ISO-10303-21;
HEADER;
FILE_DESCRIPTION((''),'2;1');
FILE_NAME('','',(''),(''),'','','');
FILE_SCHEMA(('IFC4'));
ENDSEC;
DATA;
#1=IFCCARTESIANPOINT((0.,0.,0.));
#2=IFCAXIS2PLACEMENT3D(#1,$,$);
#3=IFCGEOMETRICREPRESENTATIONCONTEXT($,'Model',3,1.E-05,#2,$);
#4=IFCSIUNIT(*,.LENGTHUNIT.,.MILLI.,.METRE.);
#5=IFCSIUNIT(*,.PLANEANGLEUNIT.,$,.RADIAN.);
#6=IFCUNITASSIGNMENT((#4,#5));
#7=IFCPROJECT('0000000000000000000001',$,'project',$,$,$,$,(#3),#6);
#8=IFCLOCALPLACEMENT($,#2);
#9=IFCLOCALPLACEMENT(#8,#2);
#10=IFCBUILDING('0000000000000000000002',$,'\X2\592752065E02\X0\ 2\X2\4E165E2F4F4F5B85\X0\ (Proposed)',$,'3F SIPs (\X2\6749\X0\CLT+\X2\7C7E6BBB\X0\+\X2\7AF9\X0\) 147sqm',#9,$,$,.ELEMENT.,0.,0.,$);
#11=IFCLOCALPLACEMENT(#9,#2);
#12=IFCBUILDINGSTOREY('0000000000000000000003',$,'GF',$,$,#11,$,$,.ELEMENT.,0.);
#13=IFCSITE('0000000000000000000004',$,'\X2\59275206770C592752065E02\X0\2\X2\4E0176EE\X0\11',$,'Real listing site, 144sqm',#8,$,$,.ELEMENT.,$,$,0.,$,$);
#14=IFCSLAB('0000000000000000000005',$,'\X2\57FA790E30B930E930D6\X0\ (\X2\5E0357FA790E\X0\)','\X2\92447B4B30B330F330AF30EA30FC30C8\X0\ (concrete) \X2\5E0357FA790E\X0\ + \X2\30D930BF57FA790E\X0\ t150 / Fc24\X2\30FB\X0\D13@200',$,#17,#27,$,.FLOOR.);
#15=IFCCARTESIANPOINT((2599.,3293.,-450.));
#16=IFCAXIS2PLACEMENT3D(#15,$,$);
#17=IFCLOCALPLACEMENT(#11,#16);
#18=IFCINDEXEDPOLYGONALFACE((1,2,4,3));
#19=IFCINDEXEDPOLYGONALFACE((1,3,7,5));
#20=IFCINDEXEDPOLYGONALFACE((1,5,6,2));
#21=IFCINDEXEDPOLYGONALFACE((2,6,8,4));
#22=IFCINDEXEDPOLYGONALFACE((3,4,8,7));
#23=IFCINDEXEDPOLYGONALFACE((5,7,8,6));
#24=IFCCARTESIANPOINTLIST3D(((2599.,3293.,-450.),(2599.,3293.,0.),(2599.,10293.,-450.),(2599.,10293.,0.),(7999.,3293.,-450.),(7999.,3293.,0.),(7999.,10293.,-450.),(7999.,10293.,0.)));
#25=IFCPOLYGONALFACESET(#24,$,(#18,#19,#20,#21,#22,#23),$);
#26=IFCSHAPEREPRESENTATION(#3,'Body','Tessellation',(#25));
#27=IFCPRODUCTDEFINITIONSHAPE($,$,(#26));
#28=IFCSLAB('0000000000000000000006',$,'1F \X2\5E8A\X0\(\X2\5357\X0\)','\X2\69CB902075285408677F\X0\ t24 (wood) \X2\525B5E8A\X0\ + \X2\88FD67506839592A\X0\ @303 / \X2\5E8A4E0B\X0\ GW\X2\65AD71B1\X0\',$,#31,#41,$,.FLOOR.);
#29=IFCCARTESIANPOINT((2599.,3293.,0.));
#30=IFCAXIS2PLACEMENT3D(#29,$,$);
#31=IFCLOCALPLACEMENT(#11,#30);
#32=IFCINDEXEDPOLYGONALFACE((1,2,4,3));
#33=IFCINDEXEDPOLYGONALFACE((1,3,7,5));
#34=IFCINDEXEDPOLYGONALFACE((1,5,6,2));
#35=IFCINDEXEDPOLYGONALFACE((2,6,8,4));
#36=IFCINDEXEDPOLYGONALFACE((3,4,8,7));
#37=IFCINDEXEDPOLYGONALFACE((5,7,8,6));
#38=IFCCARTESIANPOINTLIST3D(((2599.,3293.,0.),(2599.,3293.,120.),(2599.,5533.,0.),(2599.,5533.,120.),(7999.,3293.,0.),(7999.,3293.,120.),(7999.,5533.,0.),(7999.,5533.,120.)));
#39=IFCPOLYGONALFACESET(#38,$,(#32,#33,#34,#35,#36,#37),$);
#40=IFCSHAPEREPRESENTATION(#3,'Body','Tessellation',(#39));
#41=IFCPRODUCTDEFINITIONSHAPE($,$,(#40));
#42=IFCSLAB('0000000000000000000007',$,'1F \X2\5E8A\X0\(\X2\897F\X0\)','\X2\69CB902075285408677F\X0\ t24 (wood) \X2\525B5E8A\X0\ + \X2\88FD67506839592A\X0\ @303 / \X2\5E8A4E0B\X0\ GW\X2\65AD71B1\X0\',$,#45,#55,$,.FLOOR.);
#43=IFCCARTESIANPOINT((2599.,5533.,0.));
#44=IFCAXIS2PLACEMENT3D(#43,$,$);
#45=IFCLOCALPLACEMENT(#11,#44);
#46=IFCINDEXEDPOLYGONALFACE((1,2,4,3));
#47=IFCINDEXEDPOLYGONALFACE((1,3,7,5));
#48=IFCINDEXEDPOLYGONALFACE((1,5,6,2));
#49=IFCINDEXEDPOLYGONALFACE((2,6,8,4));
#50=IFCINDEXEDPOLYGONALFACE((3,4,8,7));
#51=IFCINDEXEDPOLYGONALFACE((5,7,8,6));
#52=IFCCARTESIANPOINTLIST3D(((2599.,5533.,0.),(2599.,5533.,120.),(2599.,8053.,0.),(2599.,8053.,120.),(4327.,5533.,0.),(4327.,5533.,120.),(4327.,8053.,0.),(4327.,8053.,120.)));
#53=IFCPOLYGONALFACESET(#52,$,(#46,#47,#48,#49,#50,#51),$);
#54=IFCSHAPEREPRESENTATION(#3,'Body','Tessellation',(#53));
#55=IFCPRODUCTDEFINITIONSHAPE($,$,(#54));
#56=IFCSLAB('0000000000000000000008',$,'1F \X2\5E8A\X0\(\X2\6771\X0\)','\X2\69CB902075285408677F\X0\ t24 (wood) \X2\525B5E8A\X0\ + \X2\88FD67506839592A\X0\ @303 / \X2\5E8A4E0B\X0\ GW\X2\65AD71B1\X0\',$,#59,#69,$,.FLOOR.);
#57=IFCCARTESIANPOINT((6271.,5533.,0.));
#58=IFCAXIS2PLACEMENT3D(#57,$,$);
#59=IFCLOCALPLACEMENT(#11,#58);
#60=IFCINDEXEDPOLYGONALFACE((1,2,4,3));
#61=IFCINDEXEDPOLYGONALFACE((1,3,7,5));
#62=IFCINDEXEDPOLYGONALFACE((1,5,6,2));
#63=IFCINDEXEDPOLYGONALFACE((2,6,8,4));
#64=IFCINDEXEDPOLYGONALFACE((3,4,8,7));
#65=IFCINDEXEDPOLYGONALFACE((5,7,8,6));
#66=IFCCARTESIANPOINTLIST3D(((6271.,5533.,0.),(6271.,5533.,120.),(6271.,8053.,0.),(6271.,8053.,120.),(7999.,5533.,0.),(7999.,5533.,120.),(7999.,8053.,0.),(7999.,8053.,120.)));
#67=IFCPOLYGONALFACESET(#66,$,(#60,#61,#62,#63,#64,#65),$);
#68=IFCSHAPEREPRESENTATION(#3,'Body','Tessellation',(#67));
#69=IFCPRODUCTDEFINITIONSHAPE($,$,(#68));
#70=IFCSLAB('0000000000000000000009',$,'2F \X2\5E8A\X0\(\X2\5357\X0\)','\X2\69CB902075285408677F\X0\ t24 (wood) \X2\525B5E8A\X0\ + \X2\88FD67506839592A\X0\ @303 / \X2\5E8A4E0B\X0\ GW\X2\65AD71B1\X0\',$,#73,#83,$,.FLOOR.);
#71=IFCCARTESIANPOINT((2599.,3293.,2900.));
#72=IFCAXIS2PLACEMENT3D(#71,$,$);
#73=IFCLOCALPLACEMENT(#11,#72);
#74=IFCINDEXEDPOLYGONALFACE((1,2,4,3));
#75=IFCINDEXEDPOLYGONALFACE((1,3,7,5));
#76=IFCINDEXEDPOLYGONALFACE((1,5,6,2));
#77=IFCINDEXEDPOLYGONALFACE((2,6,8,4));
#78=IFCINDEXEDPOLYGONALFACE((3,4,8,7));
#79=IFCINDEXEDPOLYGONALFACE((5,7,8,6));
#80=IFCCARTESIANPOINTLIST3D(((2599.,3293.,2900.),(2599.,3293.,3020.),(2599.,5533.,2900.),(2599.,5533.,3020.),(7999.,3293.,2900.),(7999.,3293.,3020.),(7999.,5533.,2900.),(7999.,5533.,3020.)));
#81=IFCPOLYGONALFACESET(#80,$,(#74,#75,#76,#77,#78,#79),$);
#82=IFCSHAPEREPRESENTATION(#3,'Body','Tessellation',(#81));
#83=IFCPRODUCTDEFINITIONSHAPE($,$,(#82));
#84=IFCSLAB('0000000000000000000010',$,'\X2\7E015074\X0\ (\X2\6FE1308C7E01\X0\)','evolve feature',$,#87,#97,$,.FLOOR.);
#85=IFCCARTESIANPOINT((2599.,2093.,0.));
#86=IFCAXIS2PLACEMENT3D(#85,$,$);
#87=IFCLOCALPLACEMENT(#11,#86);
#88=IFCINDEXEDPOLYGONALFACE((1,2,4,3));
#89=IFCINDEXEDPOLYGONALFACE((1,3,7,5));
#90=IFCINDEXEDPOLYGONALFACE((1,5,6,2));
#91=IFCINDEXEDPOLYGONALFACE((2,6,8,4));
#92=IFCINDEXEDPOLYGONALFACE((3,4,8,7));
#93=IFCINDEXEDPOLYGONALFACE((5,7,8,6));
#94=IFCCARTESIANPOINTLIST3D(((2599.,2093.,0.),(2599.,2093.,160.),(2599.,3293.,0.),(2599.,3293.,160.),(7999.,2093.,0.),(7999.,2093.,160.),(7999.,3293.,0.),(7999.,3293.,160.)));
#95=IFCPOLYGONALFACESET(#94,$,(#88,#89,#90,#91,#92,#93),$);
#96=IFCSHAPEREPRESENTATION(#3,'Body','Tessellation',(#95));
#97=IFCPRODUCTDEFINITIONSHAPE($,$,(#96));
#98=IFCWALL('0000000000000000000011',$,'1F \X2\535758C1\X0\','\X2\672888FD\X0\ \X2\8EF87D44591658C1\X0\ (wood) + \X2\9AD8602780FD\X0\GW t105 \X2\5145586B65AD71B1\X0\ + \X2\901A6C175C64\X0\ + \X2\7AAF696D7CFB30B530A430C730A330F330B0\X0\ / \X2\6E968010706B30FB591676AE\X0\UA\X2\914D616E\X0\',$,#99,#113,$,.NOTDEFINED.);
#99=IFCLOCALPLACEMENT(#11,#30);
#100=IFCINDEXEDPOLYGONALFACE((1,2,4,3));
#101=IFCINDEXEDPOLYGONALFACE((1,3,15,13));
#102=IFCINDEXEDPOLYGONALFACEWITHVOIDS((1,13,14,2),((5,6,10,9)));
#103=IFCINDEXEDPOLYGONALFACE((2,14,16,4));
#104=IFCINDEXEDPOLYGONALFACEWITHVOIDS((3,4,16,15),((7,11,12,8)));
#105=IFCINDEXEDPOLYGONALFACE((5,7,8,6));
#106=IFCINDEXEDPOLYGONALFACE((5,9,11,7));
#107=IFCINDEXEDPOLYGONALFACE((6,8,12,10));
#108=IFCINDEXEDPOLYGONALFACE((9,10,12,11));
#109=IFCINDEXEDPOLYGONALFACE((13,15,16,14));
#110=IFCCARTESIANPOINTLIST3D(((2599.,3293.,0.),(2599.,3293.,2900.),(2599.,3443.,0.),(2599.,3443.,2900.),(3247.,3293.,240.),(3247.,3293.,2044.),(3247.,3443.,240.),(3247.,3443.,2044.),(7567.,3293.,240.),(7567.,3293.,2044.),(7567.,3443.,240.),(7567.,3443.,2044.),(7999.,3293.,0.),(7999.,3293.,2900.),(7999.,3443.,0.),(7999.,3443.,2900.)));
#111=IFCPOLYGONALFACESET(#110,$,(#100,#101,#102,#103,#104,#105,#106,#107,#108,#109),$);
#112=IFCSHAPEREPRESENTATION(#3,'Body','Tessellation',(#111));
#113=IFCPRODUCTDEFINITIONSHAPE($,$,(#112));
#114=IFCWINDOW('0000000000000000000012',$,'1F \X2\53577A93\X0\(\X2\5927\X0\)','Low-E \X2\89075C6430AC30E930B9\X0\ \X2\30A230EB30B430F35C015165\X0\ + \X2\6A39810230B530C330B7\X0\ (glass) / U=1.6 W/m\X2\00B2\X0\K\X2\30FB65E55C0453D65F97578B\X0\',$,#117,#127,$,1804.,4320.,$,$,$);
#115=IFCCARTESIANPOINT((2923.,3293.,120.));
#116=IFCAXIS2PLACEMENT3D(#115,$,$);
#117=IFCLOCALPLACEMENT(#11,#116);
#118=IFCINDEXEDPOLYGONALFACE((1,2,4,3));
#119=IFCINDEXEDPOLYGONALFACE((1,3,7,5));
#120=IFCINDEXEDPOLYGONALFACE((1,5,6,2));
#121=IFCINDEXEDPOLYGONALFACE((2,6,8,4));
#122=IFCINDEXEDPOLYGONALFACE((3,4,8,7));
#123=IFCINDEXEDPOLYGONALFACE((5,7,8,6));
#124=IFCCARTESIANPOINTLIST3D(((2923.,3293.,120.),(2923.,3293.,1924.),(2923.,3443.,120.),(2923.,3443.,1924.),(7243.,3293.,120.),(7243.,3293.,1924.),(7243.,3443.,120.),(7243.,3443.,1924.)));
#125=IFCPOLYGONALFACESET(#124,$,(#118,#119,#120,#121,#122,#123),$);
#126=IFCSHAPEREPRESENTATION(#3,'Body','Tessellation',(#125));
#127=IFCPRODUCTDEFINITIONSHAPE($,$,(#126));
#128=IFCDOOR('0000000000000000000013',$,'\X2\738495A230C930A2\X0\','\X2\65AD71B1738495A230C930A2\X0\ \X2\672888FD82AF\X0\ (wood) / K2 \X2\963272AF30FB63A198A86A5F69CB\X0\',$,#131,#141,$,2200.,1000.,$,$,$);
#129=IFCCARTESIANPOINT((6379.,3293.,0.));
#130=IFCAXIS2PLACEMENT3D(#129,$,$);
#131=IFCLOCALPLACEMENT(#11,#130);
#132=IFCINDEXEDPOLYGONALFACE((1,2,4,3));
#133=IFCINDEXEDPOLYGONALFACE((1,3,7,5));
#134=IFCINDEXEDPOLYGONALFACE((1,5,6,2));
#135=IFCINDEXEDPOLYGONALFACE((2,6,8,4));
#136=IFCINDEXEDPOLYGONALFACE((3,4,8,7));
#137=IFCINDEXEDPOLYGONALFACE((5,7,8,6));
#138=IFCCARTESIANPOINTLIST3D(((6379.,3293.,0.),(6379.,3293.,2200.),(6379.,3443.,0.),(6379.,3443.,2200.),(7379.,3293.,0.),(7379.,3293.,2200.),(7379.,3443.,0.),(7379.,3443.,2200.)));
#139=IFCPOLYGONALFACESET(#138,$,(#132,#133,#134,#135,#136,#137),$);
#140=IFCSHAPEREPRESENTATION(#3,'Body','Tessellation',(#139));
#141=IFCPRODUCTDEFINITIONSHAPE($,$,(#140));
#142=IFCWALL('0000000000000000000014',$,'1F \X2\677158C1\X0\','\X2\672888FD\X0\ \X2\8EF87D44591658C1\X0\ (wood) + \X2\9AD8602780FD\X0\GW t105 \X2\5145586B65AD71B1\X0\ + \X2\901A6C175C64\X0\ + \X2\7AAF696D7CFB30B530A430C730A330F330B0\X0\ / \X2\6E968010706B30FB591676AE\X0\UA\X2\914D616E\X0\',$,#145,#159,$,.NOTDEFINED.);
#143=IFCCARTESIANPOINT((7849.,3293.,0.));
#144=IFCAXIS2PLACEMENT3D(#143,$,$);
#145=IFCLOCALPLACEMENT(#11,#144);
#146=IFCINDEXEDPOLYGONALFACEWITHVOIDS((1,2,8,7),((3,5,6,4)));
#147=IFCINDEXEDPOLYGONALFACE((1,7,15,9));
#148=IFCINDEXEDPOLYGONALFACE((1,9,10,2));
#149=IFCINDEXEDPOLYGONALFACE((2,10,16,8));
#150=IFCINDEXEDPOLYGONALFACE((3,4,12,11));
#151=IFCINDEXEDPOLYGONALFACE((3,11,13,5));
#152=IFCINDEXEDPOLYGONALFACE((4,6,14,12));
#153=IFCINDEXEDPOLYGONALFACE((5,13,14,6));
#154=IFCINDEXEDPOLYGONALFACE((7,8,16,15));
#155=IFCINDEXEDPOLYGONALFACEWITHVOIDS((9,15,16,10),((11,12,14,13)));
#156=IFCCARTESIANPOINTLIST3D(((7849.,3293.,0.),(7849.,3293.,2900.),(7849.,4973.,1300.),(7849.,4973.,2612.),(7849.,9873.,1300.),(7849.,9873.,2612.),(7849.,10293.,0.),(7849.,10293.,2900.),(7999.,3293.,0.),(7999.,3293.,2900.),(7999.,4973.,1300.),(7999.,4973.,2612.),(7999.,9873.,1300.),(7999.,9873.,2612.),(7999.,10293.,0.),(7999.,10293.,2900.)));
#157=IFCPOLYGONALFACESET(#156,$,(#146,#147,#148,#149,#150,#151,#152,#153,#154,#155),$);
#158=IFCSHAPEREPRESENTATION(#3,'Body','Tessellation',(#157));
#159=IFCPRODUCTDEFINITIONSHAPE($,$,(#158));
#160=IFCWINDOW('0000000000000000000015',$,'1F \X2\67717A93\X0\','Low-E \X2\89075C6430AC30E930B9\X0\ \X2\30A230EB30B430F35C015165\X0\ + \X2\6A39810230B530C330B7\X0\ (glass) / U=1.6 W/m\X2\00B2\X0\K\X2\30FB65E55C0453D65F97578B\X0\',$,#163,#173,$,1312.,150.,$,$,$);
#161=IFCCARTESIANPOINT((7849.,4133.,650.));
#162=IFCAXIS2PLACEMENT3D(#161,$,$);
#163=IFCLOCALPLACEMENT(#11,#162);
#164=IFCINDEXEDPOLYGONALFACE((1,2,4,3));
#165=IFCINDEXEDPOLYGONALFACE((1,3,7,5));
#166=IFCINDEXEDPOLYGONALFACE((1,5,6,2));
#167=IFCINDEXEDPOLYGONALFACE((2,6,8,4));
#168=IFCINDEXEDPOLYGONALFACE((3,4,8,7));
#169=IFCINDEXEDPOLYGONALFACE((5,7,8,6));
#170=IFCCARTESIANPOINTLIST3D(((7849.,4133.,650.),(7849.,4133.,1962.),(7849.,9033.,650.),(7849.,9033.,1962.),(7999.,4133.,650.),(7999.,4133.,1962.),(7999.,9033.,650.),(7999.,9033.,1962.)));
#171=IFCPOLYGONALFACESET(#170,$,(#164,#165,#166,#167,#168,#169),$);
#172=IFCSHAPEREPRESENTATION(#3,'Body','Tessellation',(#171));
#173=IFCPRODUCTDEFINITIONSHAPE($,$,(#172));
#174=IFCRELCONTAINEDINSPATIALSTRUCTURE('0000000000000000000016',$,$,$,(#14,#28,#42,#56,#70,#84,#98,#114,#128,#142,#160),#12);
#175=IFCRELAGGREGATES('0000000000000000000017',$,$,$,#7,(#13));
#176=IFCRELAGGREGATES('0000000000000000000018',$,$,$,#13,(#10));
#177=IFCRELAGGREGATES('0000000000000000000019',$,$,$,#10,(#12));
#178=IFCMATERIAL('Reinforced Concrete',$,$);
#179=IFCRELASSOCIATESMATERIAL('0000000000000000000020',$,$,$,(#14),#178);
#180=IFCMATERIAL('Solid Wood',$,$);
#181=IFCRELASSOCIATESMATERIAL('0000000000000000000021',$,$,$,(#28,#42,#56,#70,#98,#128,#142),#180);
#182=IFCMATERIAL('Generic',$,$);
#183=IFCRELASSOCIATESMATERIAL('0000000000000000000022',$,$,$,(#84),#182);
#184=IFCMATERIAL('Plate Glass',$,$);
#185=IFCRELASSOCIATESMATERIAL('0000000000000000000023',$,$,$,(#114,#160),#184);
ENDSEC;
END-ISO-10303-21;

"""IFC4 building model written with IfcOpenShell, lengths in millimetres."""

from ifc_helpers import new_model, si_unit, frame, frame_2d, origin, place, context, project, spatial, rectangle, extrude, material, element, fill, save


model = new_model("IFC4")

# Units and contexts
model_context = context("Model", 3, precision=1e-05, world=origin())
ifc_project = project(units=[si_unit("LENGTHUNIT", "METRE", prefix="MILLI"), si_unit("PLANEANGLEUNIT", "RADIAN")], contexts=[model_context])

# Site, building, storey
site_placement = place(None, origin())
site = spatial("IfcSite", under=ifc_project, at=site_placement, Name="大分県大分市2丁目11", ObjectType="Real listing site, 144sqm", CompositionType="ELEMENT", RefElevation=0.0)
building_placement = place(site_placement, origin())
building = spatial("IfcBuilding", under=site, at=building_placement, Name="大分市 2世帯住宅 (Proposed)", ObjectType="3F SIPs (杉CLT+籾殻+竹) 147sqm", CompositionType="ELEMENT", ElevationOfRefHeight=0.0, ElevationOfTerrain=0.0)
storey_placement = place(building_placement, origin())
storey = spatial("IfcBuildingStorey", under=building, at=storey_placement, Name="GF", CompositionType="ELEMENT", Elevation=0.0)

# Slabs
ifc_material_1 = material(Name="Reinforced Concrete")
slab_1_placement = place(storey_placement, frame((2599.0, 3293.0, -450.0)))
element("IfcSlab", 1, at=slab_1_placement, inside=storey, material=ifc_material_1, Name="基礎スラブ (布基礎)", Description="鉄筋コンクリート (concrete) 布基礎 + ベタ基礎 t150 / Fc24・D13@200", PredefinedType="FLOOR", context=model_context, shape_type="SweptSolid", body=[
    extrude(rectangle(XDim=5400.0, YDim=7000.0, at=frame_2d((2700.0, 3500.0))), frame((2599.0, 3293.0, -450.0)), (0.0, 0.0, 1.0), 450.0),
])
ifc_material_2 = material(Name="Solid Wood")
slab_2_placement = place(storey_placement, frame((2599.0, 3293.0, 0.0)))
element("IfcSlab", 2, at=slab_2_placement, inside=storey, material=ifc_material_2, Name="1F 床(南)", Description="構造用合板 t24 (wood) 剛床 + 製材根太 @303 / 床下 GW断熱", PredefinedType="FLOOR", context=model_context, shape_type="SweptSolid", body=[
    extrude(rectangle(XDim=5400.0, YDim=2240.0, at=frame_2d((2700.0, 1120.0))), frame((2599.0, 3293.0, 0.0)), (0.0, 0.0, 1.0), 120.0),
])
slab_3_placement = place(storey_placement, frame((2599.0, 5533.0, 0.0)))
element("IfcSlab", 3, at=slab_3_placement, inside=storey, material=ifc_material_2, Name="1F 床(西)", Description="構造用合板 t24 (wood) 剛床 + 製材根太 @303 / 床下 GW断熱", PredefinedType="FLOOR", context=model_context, shape_type="SweptSolid", body=[
    extrude(rectangle(XDim=1728.0, YDim=2520.0, at=frame_2d((864.0, 1260.0))), frame((2599.0, 5533.0, 0.0)), (0.0, 0.0, 1.0), 120.0),
])
slab_4_placement = place(storey_placement, frame((6271.0, 5533.0, 0.0)))
element("IfcSlab", 4, at=slab_4_placement, inside=storey, material=ifc_material_2, Name="1F 床(東)", Description="構造用合板 t24 (wood) 剛床 + 製材根太 @303 / 床下 GW断熱", PredefinedType="FLOOR", context=model_context, shape_type="SweptSolid", body=[
    extrude(rectangle(XDim=1728.0, YDim=2520.0, at=frame_2d((864.0, 1260.0))), frame((6271.0, 5533.0, 0.0)), (0.0, 0.0, 1.0), 120.0),
])
slab_5_placement = place(storey_placement, frame((2599.0, 3293.0, 2900.0)))
element("IfcSlab", 5, at=slab_5_placement, inside=storey, material=ifc_material_2, Name="2F 床(南)", Description="構造用合板 t24 (wood) 剛床 + 製材根太 @303 / 床下 GW断熱", PredefinedType="FLOOR", context=model_context, shape_type="SweptSolid", body=[
    extrude(rectangle(XDim=5400.0, YDim=2240.0, at=frame_2d((2700.0, 1120.0))), frame((2599.0, 3293.0, 2900.0)), (0.0, 0.0, 1.0), 120.0),
])
ifc_material_3 = material(Name="Generic")
slab_6_placement = place(storey_placement, frame((2599.0, 2093.0, 0.0)))
element("IfcSlab", 6, at=slab_6_placement, inside=storey, material=ifc_material_3, Name="縁側 (濡れ縁)", Description="evolve feature", PredefinedType="FLOOR", context=model_context, shape_type="SweptSolid", body=[
    extrude(rectangle(XDim=5400.0, YDim=1200.0, at=frame_2d((2700.0, 600.0))), frame((2599.0, 2093.0, 0.0)), (0.0, 0.0, 1.0), 160.0),
])

# Wall, openings, window, door
wall_1_placement = place(storey_placement, frame((2599.0, 3293.0, 0.0)))
wall_1 = element("IfcWall", 7, at=wall_1_placement, inside=storey, material=ifc_material_2, Name="1F 南壁", Description="木製 軸組外壁 (wood) + 高性能GW t105 充填断熱 + 通気層 + 窯業系サイディング / 準耐火・外皮UA配慮", PredefinedType="NOTDEFINED", context=model_context, shape_type="SweptSolid", body=[
    extrude(rectangle(XDim=5400.0, YDim=150.0, at=frame_2d((2700.0, 75.0))), frame((2599.0, 3293.0, 0.0)), (0.0, 0.0, 1.0), 2900.0),
])
opening_1_placement = place(storey_placement, frame((2923.0, 3293.0, 120.0)))
opening_1 = element("IfcOpeningElement", 8, at=opening_1_placement, cuts=wall_1, PredefinedType="NOTDEFINED", context=model_context, shape_type="SweptSolid", body=[
    extrude(rectangle(XDim=4320.0, YDim=150.0, at=frame_2d((2160.0, 75.0))), frame((2923.0, 3293.0, 120.0)), (0.0, 0.0, 1.0), 1804.0),
])
opening_2_placement = place(storey_placement, frame((6379.0, 3293.0, 0.0)))
opening_2 = element("IfcOpeningElement", 9, at=opening_2_placement, cuts=wall_1, PredefinedType="NOTDEFINED", context=model_context, shape_type="SweptSolid", body=[
    extrude(rectangle(XDim=1000.0, YDim=150.0, at=frame_2d((500.0, 75.0))), frame((6379.0, 3293.0, 0.0)), (0.0, 0.0, 1.0), 2200.0),
])
ifc_material_4 = material(Name="Plate Glass")
window_1_placement = place(storey_placement, frame((2923.0, 3293.0, 120.0)))
window_1 = element("IfcWindow", 10, at=window_1_placement, inside=storey, material=ifc_material_4, Name="1F 南窓(大)", Description="Low-E 複層ガラス アルゴン封入 + 樹脂サッシ (glass) / U=1.6 W/m²K・日射取得型", OverallHeight=1804.0, OverallWidth=4320.0, context=model_context, shape_type="SweptSolid", body=[
    extrude(rectangle(XDim=4320.0, YDim=150.0, at=frame_2d((2160.0, 75.0))), frame((2923.0, 3293.0, 120.0)), (0.0, 0.0, 1.0), 1804.0),
])
fill(opening_1, window_1)
door_placement = place(storey_placement, frame((6379.0, 3293.0, 0.0)))
door = element("IfcDoor", 11, at=door_placement, inside=storey, material=ifc_material_2, Name="玄関ドア", Description="断熱玄関ドア 木製芯 (wood) / K2 防犯・採風機構", OverallHeight=2200.0, OverallWidth=1000.0, context=model_context, shape_type="SweptSolid", body=[
    extrude(rectangle(XDim=1000.0, YDim=150.0, at=frame_2d((500.0, 75.0))), frame((6379.0, 3293.0, 0.0)), (0.0, 0.0, 1.0), 2200.0),
])
fill(opening_2, door)

# Wall, opening, window
wall_2_placement = place(storey_placement, frame((7849.0, 3293.0, 0.0)))
wall_2 = element("IfcWall", 12, at=wall_2_placement, inside=storey, material=ifc_material_2, Name="1F 東壁", Description="木製 軸組外壁 (wood) + 高性能GW t105 充填断熱 + 通気層 + 窯業系サイディング / 準耐火・外皮UA配慮", PredefinedType="NOTDEFINED", context=model_context, shape_type="SweptSolid", body=[
    extrude(rectangle(XDim=150.0, YDim=7000.0, at=frame_2d((75.0, 3500.0))), frame((7849.0, 3293.0, 0.0)), (0.0, 0.0, 1.0), 2900.0),
])
opening_3_placement = place(storey_placement, frame((7849.0, 4133.0, 650.0)))
opening_3 = element("IfcOpeningElement", 13, at=opening_3_placement, cuts=wall_2, PredefinedType="NOTDEFINED", context=model_context, shape_type="SweptSolid", body=[
    extrude(rectangle(XDim=150.0, YDim=4900.0, at=frame_2d((75.0, 2450.0))), frame((7849.0, 4133.0, 650.0)), (0.0, 0.0, 1.0), 1312.0),
])
window_2_placement = place(storey_placement, frame((7849.0, 4133.0, 650.0)))
window_2 = element("IfcWindow", 14, at=window_2_placement, inside=storey, material=ifc_material_4, Name="1F 東窓", Description="Low-E 複層ガラス アルゴン封入 + 樹脂サッシ (glass) / U=1.6 W/m²K・日射取得型", OverallHeight=1312.0, OverallWidth=150.0, context=model_context, shape_type="SweptSolid", body=[
    extrude(rectangle(XDim=150.0, YDim=4900.0, at=frame_2d((75.0, 2450.0))), frame((7849.0, 4133.0, 650.0)), (0.0, 0.0, 1.0), 1312.0),
])
fill(opening_3, window_2)

save(model, "model.ifc")
